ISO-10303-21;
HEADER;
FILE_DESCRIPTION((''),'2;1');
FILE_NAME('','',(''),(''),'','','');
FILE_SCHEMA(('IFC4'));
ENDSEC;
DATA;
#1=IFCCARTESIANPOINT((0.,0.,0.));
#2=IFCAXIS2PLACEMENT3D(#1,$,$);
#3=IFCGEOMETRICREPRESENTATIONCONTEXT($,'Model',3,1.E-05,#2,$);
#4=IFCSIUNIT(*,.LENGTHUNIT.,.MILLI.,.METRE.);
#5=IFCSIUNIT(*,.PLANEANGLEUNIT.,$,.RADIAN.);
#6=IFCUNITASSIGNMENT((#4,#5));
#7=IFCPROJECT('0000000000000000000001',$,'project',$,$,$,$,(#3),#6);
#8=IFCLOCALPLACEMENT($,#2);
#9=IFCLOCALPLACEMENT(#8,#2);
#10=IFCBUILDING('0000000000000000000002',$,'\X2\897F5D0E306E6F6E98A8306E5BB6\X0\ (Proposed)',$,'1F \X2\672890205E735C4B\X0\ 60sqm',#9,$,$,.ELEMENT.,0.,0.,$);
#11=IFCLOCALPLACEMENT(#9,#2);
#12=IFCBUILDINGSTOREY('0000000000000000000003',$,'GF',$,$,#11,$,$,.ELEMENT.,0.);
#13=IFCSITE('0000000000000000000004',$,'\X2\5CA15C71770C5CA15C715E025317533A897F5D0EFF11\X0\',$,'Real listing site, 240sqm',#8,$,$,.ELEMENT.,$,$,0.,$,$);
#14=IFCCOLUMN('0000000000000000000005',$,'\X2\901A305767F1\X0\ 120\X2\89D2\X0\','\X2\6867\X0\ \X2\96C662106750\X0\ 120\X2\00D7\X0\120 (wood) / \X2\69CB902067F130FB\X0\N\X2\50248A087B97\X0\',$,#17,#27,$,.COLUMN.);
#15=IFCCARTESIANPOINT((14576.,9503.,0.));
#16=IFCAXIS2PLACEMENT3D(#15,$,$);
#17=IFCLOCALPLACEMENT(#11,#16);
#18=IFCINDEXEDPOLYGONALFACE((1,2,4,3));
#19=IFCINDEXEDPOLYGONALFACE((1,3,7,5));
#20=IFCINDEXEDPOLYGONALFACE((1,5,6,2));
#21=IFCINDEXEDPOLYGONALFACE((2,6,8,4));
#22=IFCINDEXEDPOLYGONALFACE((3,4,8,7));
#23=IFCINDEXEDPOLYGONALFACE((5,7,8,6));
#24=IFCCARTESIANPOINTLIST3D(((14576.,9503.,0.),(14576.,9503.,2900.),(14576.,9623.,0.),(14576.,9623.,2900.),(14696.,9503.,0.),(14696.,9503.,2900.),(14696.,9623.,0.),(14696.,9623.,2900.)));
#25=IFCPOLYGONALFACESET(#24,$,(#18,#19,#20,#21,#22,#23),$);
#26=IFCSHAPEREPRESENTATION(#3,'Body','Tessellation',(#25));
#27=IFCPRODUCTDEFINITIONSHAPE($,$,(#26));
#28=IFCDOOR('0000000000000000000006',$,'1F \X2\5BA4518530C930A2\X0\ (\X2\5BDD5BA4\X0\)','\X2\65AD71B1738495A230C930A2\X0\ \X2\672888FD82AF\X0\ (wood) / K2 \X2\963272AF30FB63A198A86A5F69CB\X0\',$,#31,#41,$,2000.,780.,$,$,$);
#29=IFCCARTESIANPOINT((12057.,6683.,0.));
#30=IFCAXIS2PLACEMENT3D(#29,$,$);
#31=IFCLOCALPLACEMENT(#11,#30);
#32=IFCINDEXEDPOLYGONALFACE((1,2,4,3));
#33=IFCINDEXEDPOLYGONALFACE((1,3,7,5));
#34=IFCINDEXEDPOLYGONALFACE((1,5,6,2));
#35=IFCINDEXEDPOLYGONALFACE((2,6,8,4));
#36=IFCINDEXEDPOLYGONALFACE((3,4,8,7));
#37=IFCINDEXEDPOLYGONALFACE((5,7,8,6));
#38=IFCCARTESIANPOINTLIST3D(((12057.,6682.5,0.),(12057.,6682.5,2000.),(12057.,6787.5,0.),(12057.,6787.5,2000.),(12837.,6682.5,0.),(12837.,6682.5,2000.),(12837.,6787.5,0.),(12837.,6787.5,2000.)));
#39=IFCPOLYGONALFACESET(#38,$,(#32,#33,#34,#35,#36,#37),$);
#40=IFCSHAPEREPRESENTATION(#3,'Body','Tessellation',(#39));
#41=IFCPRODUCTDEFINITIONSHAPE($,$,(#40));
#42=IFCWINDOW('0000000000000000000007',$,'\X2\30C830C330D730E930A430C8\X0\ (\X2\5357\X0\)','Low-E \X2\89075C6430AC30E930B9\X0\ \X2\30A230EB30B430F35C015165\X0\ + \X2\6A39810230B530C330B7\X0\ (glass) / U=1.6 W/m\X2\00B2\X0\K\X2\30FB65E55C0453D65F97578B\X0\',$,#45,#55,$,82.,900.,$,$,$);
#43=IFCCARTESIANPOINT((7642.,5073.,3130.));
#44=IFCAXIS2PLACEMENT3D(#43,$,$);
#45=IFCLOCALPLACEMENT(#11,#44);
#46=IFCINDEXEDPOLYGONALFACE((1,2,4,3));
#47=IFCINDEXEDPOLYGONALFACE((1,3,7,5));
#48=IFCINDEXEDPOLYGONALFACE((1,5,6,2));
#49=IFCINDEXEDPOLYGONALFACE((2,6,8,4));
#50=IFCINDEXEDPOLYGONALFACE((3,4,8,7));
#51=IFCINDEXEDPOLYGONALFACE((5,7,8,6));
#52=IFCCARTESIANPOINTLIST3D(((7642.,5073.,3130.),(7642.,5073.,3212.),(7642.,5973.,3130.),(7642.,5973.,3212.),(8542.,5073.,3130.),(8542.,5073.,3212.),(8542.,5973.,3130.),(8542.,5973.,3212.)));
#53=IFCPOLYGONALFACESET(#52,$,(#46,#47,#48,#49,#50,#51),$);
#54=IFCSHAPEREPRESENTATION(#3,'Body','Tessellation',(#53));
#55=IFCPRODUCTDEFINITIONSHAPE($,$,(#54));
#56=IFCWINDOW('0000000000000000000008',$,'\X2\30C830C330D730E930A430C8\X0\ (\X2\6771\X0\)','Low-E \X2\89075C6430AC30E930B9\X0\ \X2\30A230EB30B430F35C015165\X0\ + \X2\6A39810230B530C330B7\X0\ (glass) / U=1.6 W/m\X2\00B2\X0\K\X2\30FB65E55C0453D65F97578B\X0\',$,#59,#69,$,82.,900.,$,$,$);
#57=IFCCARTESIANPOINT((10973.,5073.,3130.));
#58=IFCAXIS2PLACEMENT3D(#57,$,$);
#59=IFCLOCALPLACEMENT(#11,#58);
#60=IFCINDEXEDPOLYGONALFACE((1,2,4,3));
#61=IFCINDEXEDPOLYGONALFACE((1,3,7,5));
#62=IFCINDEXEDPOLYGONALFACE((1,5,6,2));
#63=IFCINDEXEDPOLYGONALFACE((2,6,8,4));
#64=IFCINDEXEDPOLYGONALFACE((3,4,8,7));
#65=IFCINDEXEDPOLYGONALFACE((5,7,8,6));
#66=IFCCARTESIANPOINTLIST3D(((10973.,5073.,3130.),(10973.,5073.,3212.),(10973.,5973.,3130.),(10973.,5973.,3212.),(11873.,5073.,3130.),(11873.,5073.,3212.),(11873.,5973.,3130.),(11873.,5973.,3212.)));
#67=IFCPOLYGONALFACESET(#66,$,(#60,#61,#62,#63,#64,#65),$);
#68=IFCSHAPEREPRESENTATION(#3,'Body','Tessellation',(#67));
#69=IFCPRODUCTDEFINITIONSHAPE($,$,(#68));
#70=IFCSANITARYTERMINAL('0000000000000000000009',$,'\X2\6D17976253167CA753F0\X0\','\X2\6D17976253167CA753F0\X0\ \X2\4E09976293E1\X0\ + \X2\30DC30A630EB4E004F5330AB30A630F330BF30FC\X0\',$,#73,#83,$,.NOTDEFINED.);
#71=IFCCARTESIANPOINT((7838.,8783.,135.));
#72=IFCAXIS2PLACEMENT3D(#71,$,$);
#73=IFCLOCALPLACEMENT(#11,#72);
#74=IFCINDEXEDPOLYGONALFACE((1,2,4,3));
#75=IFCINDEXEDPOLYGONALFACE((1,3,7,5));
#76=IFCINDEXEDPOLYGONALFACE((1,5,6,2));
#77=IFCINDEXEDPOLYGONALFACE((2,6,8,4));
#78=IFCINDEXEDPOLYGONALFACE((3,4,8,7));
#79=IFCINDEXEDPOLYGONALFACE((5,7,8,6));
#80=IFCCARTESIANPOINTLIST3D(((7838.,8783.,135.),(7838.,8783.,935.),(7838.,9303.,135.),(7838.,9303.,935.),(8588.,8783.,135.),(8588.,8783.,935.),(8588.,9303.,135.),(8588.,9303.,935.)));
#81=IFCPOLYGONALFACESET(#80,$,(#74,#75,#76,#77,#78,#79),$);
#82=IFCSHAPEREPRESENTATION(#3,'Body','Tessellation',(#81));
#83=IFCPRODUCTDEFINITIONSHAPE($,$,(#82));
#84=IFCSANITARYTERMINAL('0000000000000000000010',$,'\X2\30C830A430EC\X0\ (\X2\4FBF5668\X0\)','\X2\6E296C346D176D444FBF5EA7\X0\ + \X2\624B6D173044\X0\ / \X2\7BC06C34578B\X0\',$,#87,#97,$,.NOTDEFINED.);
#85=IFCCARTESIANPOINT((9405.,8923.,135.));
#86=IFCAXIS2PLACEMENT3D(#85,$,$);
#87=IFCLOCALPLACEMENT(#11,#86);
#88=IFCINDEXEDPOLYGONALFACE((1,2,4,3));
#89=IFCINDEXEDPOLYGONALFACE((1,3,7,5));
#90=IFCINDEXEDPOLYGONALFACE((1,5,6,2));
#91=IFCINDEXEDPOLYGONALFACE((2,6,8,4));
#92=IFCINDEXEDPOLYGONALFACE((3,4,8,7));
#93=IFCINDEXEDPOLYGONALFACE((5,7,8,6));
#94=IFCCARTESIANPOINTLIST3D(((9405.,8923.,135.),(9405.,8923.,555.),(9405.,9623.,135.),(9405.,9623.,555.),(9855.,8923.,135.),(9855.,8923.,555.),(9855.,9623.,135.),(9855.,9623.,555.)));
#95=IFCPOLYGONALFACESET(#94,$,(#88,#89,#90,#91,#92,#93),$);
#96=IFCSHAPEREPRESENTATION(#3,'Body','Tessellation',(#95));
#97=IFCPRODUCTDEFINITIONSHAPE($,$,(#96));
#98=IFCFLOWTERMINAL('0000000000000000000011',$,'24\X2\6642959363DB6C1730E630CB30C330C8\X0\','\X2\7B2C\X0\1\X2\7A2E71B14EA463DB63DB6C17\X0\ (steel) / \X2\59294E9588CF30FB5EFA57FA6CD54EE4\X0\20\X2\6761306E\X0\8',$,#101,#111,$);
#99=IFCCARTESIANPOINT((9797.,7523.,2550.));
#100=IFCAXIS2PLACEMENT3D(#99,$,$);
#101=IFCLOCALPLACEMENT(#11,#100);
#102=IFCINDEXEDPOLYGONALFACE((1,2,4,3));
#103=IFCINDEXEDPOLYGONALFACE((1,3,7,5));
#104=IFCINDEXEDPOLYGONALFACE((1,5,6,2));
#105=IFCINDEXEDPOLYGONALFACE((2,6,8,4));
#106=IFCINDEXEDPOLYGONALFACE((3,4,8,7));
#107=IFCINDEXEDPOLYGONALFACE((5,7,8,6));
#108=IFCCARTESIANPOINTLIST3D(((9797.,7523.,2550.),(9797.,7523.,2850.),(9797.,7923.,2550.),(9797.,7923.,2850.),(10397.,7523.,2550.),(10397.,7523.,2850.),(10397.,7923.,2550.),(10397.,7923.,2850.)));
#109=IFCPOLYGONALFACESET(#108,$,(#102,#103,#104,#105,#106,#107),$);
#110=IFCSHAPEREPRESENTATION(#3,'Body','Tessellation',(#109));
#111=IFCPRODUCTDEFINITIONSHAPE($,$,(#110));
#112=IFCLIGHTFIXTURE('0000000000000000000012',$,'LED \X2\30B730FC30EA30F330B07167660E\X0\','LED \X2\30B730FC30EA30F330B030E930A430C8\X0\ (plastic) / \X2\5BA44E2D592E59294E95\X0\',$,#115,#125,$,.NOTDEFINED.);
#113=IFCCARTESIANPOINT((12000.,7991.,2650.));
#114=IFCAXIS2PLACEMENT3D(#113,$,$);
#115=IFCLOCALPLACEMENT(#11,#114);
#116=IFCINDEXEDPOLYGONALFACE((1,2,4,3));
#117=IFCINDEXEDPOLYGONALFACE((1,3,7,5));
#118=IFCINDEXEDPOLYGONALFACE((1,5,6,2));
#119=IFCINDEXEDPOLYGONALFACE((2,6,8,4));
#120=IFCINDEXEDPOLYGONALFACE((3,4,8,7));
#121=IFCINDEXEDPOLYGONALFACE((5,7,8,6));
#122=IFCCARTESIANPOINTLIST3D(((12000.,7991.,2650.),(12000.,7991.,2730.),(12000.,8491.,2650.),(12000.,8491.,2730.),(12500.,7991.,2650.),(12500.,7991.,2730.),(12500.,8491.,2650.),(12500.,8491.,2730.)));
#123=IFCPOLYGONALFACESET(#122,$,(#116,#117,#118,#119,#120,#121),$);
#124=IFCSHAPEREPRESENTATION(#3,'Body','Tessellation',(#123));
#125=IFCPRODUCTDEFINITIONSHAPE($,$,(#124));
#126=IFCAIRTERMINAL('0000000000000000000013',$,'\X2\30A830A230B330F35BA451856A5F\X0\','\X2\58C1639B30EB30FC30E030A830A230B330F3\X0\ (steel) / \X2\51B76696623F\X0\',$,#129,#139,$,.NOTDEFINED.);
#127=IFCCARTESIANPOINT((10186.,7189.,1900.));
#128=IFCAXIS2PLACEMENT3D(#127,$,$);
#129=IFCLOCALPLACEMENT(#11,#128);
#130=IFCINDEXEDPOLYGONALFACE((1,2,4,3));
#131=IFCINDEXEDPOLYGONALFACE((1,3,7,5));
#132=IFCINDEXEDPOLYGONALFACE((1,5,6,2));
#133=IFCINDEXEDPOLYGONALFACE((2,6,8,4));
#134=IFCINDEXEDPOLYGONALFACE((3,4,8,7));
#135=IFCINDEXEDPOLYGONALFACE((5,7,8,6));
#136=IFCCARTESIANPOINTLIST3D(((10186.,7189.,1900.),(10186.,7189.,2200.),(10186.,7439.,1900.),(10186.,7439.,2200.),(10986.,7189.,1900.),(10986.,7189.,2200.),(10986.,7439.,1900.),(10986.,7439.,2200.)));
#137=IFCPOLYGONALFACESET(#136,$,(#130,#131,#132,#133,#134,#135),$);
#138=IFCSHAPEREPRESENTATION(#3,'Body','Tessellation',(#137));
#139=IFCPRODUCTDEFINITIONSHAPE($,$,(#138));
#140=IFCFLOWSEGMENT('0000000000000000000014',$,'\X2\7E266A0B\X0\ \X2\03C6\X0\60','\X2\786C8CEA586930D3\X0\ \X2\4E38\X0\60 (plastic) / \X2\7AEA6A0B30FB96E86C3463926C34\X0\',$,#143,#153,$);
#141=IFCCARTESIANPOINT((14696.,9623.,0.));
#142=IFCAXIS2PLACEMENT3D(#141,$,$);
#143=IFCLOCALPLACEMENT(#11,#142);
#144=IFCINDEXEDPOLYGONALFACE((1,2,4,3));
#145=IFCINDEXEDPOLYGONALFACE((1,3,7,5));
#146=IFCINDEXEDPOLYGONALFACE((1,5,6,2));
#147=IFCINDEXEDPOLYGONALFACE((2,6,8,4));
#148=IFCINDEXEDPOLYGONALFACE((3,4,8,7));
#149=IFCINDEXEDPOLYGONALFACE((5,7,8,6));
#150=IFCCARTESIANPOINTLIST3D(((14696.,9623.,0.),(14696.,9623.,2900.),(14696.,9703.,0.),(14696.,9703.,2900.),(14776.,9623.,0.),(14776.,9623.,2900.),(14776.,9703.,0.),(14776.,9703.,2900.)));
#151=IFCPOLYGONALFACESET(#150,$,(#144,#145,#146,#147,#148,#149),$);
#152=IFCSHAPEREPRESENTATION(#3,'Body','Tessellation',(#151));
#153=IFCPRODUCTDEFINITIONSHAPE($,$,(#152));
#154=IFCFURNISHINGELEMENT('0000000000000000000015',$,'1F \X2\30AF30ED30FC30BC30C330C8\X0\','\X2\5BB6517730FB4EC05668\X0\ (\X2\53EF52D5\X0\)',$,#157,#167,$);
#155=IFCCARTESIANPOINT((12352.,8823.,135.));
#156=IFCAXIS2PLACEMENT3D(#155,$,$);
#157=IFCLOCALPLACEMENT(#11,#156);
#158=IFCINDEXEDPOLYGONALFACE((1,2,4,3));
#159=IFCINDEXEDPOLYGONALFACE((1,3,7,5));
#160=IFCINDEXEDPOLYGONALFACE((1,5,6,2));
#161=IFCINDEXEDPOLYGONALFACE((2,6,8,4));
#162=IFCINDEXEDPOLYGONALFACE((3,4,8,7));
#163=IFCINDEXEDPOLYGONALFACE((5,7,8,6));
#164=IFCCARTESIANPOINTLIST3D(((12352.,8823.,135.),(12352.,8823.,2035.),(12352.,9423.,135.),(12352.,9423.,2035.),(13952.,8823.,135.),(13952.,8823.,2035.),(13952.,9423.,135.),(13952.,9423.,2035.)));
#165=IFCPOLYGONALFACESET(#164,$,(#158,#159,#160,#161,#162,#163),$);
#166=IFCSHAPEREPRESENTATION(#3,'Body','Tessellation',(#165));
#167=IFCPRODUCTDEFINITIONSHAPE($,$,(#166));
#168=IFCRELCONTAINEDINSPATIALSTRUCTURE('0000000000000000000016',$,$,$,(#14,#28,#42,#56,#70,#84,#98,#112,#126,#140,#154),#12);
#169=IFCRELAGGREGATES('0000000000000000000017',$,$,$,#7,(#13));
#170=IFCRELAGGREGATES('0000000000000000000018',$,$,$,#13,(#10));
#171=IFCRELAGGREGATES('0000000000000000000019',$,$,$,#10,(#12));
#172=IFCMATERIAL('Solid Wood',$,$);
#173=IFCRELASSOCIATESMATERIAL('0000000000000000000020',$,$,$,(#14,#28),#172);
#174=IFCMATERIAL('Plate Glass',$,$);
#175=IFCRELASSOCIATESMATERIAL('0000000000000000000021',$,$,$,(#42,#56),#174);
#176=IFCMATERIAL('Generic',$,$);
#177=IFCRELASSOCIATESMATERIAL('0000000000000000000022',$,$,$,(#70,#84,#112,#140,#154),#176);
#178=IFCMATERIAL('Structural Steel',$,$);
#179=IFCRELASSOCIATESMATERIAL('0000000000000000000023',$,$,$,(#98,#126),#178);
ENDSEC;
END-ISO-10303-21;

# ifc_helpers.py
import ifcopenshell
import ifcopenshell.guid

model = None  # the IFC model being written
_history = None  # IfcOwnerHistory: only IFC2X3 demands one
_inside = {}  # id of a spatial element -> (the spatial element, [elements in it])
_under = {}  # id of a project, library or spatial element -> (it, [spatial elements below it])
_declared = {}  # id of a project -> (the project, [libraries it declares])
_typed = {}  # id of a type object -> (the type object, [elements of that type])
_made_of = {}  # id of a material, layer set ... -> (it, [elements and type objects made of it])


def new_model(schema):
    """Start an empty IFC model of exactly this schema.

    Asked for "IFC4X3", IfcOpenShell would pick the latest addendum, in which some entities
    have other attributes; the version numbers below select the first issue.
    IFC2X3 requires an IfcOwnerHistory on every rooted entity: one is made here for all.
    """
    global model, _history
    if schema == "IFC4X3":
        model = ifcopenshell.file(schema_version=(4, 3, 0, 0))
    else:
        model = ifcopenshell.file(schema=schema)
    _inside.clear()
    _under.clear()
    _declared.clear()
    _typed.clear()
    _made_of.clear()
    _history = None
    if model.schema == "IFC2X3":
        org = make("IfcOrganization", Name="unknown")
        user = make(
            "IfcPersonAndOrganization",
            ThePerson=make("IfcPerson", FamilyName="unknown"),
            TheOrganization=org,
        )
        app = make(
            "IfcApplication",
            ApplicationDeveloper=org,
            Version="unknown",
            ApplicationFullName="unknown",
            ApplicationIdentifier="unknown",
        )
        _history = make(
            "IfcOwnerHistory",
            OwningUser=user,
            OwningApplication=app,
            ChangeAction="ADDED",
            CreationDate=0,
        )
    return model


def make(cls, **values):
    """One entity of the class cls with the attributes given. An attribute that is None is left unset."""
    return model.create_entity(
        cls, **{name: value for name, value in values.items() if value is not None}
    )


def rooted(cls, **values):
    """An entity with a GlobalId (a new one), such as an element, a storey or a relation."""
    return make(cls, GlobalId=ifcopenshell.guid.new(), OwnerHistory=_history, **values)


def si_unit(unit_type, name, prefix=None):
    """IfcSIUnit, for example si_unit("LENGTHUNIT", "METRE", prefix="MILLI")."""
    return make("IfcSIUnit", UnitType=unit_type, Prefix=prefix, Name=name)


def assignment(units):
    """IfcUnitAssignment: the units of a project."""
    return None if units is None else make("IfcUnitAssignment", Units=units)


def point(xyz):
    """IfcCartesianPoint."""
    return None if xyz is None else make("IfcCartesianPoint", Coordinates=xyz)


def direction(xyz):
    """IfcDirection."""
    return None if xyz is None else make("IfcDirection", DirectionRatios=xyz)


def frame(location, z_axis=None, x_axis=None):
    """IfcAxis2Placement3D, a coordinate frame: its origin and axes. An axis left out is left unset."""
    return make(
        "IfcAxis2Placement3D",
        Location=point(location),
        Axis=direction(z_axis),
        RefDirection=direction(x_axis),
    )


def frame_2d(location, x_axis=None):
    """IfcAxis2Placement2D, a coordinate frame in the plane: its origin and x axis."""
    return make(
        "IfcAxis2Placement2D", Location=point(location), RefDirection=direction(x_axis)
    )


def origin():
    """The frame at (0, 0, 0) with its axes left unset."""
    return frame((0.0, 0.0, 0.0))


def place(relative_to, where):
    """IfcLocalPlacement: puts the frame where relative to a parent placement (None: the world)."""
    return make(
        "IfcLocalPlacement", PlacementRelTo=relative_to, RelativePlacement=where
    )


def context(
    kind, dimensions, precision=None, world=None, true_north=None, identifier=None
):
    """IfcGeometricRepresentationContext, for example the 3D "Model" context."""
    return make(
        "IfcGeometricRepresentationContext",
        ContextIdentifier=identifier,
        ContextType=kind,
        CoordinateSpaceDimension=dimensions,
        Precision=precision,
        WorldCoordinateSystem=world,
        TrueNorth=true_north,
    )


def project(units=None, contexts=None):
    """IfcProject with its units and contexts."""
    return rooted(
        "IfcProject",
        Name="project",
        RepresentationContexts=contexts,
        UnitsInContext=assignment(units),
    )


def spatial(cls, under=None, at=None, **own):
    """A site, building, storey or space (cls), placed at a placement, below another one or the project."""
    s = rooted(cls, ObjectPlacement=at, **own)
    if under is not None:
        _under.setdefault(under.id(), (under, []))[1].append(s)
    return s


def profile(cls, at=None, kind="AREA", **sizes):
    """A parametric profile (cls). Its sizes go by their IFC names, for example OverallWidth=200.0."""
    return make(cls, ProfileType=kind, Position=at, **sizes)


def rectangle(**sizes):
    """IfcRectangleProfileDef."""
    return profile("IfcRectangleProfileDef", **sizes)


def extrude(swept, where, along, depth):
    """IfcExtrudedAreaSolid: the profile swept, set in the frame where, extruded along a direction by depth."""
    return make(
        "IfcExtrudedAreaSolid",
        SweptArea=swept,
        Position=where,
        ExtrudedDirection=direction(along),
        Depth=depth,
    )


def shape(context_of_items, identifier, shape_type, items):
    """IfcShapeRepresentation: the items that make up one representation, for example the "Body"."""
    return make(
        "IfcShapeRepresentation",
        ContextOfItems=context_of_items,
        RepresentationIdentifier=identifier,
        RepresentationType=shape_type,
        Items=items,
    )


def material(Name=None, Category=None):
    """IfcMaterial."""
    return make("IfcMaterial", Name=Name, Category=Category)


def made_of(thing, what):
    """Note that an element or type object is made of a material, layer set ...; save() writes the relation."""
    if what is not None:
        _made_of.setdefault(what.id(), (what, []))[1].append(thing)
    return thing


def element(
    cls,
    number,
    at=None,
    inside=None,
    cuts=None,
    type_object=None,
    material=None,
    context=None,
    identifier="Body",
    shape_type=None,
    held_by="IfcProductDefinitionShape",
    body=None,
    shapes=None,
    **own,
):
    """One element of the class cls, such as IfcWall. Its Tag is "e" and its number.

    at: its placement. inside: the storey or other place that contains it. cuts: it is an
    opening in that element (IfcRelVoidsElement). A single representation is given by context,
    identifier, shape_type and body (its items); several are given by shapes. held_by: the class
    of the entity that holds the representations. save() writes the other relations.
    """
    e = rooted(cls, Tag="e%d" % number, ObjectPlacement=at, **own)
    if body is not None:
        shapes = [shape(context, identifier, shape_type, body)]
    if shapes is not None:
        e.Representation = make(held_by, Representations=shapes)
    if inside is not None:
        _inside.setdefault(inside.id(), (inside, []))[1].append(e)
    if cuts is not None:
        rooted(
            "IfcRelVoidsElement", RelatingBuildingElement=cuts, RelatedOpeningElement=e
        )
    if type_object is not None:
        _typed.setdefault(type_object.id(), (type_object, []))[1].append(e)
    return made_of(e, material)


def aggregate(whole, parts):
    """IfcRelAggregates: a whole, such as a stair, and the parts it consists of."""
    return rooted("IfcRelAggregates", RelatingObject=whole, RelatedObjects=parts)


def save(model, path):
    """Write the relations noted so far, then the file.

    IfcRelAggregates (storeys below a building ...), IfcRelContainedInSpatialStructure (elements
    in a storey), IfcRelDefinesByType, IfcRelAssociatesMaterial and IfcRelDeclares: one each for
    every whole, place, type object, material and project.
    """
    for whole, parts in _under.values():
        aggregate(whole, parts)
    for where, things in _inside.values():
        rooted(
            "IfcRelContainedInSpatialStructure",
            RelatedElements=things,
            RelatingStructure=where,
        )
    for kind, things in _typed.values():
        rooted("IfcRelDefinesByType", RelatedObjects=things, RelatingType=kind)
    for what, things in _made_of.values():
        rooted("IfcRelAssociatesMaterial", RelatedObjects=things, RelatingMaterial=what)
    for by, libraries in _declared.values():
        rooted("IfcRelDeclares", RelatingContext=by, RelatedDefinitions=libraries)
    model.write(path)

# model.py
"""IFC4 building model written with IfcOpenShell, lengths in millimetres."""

from ifc_helpers import new_model, si_unit, frame, frame_2d, origin, place, context, project, spatial, rectangle, extrude, material, element, save


model = new_model("IFC4")

# Units and contexts
model_context = context("Model", 3, precision=1e-05, world=origin())
ifc_project = project(units=[si_unit("LENGTHUNIT", "METRE", prefix="MILLI"), si_unit("PLANEANGLEUNIT", "RADIAN")], contexts=[model_context])

# Site, building, storey
site_placement = place(None, origin())
site = spatial("IfcSite", under=ifc_project, at=site_placement, Name="岡山県岡山市北区西崎１", ObjectType="Real listing site, 240sqm", CompositionType="ELEMENT", RefElevation=0.0)
building_placement = place(site_placement, origin())
building = spatial("IfcBuilding", under=site, at=building_placement, Name="西崎の潮風の家 (Proposed)", ObjectType="1F 木造平屋 60sqm", CompositionType="ELEMENT", ElevationOfRefHeight=0.0, ElevationOfTerrain=0.0)
storey_placement = place(building_placement, origin())
storey = spatial("IfcBuildingStorey", under=building, at=storey_placement, Name="GF", CompositionType="ELEMENT", Elevation=0.0)

# Column
ifc_material_1 = material(Name="Solid Wood")
column_1_placement = place(storey_placement, frame((14576.0, 9503.0, 0.0)))
element("IfcColumn", 1, at=column_1_placement, inside=storey, material=ifc_material_1, Name="通し柱 120角", Description="桧 集成材 120×120 (wood) / 構造柱・N値計算", PredefinedType="COLUMN", context=model_context, shape_type="SweptSolid", body=[
    extrude(rectangle(XDim=120.0, YDim=120.0, at=frame_2d((60.0, 60.0))), frame((14576.0, 9503.0, 0.0)), (0.0, 0.0, 1.0), 2900.0),
])

# Door
door_placement = place(storey_placement, frame((12057.0, 6683.0, 0.0)))
element("IfcDoor", 2, at=door_placement, inside=storey, material=ifc_material_1, Name="1F 室内ドア (寝室)", Description="断熱玄関ドア 木製芯 (wood) / K2 防犯・採風機構", OverallHeight=2000.0, OverallWidth=780.0, context=model_context, shape_type="SweptSolid", body=[
    extrude(rectangle(XDim=780.0, YDim=105.0, at=frame_2d((390.0, 52.0))), frame((12057.0, 6683.0, 0.0)), (0.0, 0.0, 1.0), 2000.0),
])

# Windows
ifc_material_2 = material(Name="Plate Glass")
window_1_placement = place(storey_placement, frame((7642.0, 5073.0, 3130.0)))
element("IfcWindow", 3, at=window_1_placement, inside=storey, material=ifc_material_2, Name="トップライト (南)", Description="Low-E 複層ガラス アルゴン封入 + 樹脂サッシ (glass) / U=1.6 W/m²K・日射取得型", OverallHeight=82.0, OverallWidth=900.0, context=model_context, shape_type="SweptSolid", body=[
    extrude(rectangle(XDim=900.0, YDim=900.0, at=frame_2d((450.0, 450.0))), frame((7642.0, 5073.0, 3130.0)), (0.0, 0.0, 1.0), 82.0),
])
window_2_placement = place(storey_placement, frame((10973.0, 5073.0, 3130.0)))
element("IfcWindow", 4, at=window_2_placement, inside=storey, material=ifc_material_2, Name="トップライト (東)", Description="Low-E 複層ガラス アルゴン封入 + 樹脂サッシ (glass) / U=1.6 W/m²K・日射取得型", OverallHeight=82.0, OverallWidth=900.0, context=model_context, shape_type="SweptSolid", body=[
    extrude(rectangle(XDim=900.0, YDim=900.0, at=frame_2d((450.0, 450.0))), frame((10973.0, 5073.0, 3130.0)), (0.0, 0.0, 1.0), 82.0),
])

# Sanitary terminals
ifc_material_3 = material(Name="Generic")
sanitary_terminal_1_placement = place(storey_placement, frame((7838.0, 8783.0, 135.0)))
element("IfcSanitaryTerminal", 5, at=sanitary_terminal_1_placement, inside=storey, material=ifc_material_3, Name="洗面化粧台", Description="洗面化粧台 三面鏡 + ボウル一体カウンター", PredefinedType="NOTDEFINED", context=model_context, shape_type="SweptSolid", body=[
    extrude(rectangle(XDim=750.0, YDim=520.0, at=frame_2d((375.0, 260.0))), frame((7838.0, 8783.0, 135.0)), (0.0, 0.0, 1.0), 800.0),
])
sanitary_terminal_2_placement = place(storey_placement, frame((9405.0, 8923.0, 135.0)))
element("IfcSanitaryTerminal", 6, at=sanitary_terminal_2_placement, inside=storey, material=ifc_material_3, Name="トイレ (便器)", Description="温水洗浄便座 + 手洗い / 節水型", PredefinedType="NOTDEFINED", context=model_context, shape_type="SweptSolid", body=[
    extrude(rectangle(XDim=450.0, YDim=700.0, at=frame_2d((225.0, 350.0))), frame((9405.0, 8923.0, 135.0)), (0.0, 0.0, 1.0), 420.0),
])

# Flow terminal
ifc_material_4 = material(Name="Structural Steel")
flow_terminal_placement = place(storey_placement, frame((9797.0, 7523.0, 2550.0)))
element("IfcFlowTerminal", 7, at=flow_terminal_placement, inside=storey, material=ifc_material_4, Name="24時間換気ユニット", Description="第1種熱交換換気 (steel) / 天井裏・建基法令20条の8", context=model_context, shape_type="SweptSolid", body=[
    extrude(rectangle(XDim=600.0, YDim=400.0, at=frame_2d((300.0, 200.0))), frame((9797.0, 7523.0, 2550.0)), (0.0, 0.0, 1.0), 300.0),
])

# Light fixture
light_fixture_placement = place(storey_placement, frame((12000.0, 7991.0, 2650.0)))
element("IfcLightFixture", 8, at=light_fixture_placement, inside=storey, material=ifc_material_3, Name="LED シーリング照明", Description="LED シーリングライト (plastic) / 室中央天井", PredefinedType="NOTDEFINED", context=model_context, shape_type="SweptSolid", body=[
    extrude(rectangle(XDim=500.0, YDim=500.0, at=frame_2d((250.0, 250.0))), frame((12000.0, 7991.0, 2650.0)), (0.0, 0.0, 1.0), 80.0),
])

# Air terminal
air_terminal_placement = place(storey_placement, frame((10186.0, 7189.0, 1900.0)))
element("IfcAirTerminal", 9, at=air_terminal_placement, inside=storey, material=ifc_material_4, Name="エアコン室内機", Description="壁掛ルームエアコン (steel) / 冷暖房", PredefinedType="NOTDEFINED", context=model_context, shape_type="SweptSolid", body=[
    extrude(rectangle(XDim=800.0, YDim=250.0, at=frame_2d((400.0, 125.0))), frame((10186.0, 7189.0, 1900.0)), (0.0, 0.0, 1.0), 300.0),
])

# Flow segment
flow_segment_placement = place(storey_placement, frame((14696.0, 9623.0, 0.0)))
element("IfcFlowSegment", 10, at=flow_segment_placement, inside=storey, material=ifc_material_3, Name="縦樋 φ60", Description="硬質塩ビ 丸60 (plastic) / 竪樋・雨水排水", context=model_context, shape_type="SweptSolid", body=[
    extrude(rectangle(XDim=80.0, YDim=80.0, at=frame_2d((40.0, 40.0))), frame((14696.0, 9623.0, 0.0)), (0.0, 0.0, 1.0), 2900.0),
])

# Furnishing element
furnishing_placement = place(storey_placement, frame((12352.0, 8823.0, 135.0)))
element("IfcFurnishingElement", 11, at=furnishing_placement, inside=storey, material=ifc_material_3, Name="1F クローゼット", Description="家具・什器 (可動)", context=model_context, shape_type="SweptSolid", body=[
    extrude(rectangle(XDim=1600.0, YDim=600.0, at=frame_2d((800.0, 300.0))), frame((12352.0, 8823.0, 135.0)), (0.0, 0.0, 1.0), 1900.0),
])

save(model, "model.ifc")
